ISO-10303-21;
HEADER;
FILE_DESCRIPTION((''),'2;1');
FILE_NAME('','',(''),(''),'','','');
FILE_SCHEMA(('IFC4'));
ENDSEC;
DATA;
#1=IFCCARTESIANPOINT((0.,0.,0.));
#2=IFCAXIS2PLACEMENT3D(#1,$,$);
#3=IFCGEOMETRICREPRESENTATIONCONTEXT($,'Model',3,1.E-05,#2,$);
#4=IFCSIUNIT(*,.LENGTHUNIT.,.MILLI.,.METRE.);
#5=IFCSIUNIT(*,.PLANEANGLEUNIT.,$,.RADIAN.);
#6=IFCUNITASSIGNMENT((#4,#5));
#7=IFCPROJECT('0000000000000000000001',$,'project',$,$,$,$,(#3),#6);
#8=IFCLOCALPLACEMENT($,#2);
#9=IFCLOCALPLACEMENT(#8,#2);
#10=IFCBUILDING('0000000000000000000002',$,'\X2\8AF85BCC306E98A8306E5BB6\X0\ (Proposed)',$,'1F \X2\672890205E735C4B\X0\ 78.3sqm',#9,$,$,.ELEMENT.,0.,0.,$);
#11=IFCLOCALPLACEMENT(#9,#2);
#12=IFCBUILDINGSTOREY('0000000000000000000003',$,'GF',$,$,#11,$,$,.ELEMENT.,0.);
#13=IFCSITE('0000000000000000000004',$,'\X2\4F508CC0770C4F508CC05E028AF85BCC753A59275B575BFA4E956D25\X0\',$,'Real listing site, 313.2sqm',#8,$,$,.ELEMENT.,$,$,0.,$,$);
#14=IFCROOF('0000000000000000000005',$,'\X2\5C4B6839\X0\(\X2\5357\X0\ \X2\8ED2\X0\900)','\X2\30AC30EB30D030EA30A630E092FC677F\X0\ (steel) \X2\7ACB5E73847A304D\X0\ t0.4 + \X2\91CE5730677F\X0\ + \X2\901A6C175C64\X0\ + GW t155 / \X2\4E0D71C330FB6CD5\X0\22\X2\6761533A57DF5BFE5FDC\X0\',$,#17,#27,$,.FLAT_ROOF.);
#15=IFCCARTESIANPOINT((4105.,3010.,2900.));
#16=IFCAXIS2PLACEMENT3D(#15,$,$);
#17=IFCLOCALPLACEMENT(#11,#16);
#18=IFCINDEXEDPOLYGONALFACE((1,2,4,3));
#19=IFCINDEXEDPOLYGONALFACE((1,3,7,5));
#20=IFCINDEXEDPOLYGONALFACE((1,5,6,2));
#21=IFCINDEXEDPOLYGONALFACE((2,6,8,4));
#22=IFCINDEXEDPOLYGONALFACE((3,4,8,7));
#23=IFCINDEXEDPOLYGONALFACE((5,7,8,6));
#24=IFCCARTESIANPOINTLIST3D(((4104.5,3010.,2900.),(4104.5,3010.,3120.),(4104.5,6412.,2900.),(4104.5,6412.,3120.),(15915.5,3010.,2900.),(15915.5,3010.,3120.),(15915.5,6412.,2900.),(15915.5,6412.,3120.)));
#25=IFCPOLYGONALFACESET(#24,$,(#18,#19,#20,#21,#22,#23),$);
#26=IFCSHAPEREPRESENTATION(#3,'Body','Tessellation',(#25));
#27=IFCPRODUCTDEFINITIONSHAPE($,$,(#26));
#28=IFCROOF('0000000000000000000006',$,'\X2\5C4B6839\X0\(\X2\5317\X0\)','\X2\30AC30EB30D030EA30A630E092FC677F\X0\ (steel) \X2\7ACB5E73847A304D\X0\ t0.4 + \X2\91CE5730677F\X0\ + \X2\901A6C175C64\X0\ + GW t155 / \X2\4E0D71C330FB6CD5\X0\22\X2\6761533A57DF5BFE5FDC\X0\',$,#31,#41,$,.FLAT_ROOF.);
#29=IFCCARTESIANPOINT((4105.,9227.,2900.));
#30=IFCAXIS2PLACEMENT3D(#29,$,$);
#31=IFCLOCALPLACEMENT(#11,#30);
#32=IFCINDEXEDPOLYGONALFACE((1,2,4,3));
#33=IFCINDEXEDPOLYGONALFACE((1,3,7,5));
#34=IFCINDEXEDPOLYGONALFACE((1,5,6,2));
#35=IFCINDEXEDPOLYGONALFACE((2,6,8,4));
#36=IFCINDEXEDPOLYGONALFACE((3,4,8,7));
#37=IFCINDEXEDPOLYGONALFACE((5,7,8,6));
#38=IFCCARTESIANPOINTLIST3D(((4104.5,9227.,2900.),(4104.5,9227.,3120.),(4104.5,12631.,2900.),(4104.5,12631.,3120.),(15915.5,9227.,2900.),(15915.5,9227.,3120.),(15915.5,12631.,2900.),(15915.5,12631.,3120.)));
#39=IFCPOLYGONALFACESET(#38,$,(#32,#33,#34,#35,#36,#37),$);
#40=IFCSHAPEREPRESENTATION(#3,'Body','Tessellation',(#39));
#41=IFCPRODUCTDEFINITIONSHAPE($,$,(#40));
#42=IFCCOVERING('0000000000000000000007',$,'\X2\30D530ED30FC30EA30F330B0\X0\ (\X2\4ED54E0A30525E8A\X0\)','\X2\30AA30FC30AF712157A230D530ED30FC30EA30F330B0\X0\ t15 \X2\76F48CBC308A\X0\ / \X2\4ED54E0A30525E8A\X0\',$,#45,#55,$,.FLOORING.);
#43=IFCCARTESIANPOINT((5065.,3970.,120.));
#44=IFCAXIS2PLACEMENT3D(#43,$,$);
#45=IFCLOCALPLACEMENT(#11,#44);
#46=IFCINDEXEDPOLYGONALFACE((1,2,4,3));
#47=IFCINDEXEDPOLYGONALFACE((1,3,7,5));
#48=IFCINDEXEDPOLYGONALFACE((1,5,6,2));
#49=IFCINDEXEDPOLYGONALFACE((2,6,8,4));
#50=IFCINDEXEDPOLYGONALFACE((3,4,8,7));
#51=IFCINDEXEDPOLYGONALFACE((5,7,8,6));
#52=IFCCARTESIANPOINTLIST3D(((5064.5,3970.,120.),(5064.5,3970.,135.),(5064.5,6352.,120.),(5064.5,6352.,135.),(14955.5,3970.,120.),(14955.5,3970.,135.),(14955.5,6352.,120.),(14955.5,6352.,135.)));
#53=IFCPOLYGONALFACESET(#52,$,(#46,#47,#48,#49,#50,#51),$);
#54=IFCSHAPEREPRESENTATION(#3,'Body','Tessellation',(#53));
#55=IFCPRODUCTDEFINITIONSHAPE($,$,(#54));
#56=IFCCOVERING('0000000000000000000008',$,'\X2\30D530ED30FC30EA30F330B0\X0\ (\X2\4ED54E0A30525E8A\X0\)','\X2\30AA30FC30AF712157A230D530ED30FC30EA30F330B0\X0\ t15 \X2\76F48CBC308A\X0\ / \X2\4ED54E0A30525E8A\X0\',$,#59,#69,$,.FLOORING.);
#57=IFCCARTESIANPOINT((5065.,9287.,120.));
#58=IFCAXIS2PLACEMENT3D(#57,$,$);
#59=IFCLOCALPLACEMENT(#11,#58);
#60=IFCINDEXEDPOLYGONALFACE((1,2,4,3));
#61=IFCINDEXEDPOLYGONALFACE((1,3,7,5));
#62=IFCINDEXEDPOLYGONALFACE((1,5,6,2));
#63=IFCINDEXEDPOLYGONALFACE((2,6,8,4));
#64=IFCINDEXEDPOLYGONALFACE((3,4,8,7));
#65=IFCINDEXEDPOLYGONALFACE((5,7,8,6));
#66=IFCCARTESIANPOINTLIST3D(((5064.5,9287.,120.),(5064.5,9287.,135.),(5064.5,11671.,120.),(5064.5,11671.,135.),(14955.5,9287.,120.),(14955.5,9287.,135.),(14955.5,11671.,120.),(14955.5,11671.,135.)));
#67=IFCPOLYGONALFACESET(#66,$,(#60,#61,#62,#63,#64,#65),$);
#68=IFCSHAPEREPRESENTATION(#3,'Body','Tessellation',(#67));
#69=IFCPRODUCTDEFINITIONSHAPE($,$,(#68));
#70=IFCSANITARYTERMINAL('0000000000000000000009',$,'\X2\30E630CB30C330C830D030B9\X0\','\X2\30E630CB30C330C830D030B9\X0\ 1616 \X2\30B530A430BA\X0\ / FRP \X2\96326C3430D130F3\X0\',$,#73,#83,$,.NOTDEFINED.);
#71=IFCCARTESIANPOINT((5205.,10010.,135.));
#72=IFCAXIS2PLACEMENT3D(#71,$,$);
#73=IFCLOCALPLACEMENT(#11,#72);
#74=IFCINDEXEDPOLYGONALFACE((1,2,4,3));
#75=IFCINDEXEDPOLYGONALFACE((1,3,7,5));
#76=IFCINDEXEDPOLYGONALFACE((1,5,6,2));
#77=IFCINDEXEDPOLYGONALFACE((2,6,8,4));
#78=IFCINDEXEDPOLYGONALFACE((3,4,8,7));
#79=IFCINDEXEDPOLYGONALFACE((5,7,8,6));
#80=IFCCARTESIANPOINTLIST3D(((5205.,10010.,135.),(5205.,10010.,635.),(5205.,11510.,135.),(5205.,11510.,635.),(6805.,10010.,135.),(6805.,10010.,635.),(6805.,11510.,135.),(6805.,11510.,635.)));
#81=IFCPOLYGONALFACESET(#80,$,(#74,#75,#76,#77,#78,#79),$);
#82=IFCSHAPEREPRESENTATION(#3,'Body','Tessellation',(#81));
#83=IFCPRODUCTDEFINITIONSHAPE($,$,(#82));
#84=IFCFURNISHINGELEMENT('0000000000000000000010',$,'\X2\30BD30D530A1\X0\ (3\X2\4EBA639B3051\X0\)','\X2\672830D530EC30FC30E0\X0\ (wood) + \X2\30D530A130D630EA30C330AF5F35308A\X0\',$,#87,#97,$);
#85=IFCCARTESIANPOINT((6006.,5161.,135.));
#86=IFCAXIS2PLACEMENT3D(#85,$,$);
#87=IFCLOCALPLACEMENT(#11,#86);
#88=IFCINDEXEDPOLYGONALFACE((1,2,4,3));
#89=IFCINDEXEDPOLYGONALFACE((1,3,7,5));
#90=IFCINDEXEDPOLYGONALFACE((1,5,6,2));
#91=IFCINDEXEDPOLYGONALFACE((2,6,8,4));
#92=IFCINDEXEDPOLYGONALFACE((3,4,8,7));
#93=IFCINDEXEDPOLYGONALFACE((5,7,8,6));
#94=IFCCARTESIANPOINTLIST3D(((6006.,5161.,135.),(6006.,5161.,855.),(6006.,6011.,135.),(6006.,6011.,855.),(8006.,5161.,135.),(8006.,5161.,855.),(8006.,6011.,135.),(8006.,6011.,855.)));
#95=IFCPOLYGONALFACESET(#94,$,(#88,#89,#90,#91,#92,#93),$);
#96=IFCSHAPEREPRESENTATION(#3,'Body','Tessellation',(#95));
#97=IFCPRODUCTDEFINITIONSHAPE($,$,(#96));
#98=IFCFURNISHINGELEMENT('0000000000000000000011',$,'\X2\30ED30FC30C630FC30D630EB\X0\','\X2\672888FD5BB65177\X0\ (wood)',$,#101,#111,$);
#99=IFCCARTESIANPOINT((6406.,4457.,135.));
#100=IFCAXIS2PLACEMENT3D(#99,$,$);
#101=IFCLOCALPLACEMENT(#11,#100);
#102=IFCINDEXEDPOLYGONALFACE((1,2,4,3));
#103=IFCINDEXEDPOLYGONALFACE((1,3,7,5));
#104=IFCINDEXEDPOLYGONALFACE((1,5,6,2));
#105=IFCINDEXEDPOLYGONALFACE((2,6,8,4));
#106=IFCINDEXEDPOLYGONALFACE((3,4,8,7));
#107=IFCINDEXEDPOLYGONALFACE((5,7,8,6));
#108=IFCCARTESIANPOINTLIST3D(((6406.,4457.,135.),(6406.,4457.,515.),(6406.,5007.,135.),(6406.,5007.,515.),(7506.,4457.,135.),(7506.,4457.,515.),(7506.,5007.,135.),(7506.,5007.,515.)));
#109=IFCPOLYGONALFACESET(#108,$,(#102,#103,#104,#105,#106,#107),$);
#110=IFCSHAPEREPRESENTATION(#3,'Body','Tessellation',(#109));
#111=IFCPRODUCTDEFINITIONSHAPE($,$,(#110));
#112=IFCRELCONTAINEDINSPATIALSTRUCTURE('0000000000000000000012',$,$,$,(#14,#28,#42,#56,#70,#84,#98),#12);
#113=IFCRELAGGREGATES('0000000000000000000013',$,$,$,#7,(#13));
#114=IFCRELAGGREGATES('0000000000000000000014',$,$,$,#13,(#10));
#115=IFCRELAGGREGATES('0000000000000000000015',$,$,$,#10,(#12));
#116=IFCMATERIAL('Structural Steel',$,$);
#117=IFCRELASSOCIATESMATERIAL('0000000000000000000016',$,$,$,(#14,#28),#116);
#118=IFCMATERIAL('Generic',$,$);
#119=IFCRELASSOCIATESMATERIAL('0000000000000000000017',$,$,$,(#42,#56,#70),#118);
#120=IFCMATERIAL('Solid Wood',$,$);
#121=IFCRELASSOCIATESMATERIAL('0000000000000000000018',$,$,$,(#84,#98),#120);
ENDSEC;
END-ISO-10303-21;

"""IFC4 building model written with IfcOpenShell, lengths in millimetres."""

from ifc_helpers import new_model, si_unit, frame, frame_2d, origin, place, context, project, spatial, rectangle, extrude, material, element, save


model = new_model("IFC4")

# Units and contexts
model_context = context("Model", 3, precision=1e-05, world=origin())
ifc_project = project(units=[si_unit("LENGTHUNIT", "METRE", prefix="MILLI"), si_unit("PLANEANGLEUNIT", "RADIAN")], contexts=[model_context])

# Site, building, storey
site_placement = place(None, origin())
site = spatial("IfcSite", under=ifc_project, at=site_placement, Name="佐賀県佐賀市諸富町大字寺井津", ObjectType="Real listing site, 313.2sqm", CompositionType="ELEMENT", RefElevation=0.0)
building_placement = place(site_placement, origin())
building = spatial("IfcBuilding", under=site, at=building_placement, Name="諸富の風の家 (Proposed)", ObjectType="1F 木造平屋 78.3sqm", CompositionType="ELEMENT", ElevationOfRefHeight=0.0, ElevationOfTerrain=0.0)
storey_placement = place(building_placement, origin())
storey = spatial("IfcBuildingStorey", under=building, at=storey_placement, Name="GF", CompositionType="ELEMENT", Elevation=0.0)

# Shared definitions
ifc_material_1 = material(Name="Solid Wood")

# Roofs
ifc_material_2 = material(Name="Structural Steel")
roof_1_placement = place(storey_placement, frame((4105.0, 3010.0, 2900.0)))
element("IfcRoof", 1, at=roof_1_placement, inside=storey, material=ifc_material_2, Name="屋根(南 軒900)", Description="ガルバリウム鋼板 (steel) 立平葺き t0.4 + 野地板 + 通気層 + GW t155 / 不燃・法22条区域対応", PredefinedType="FLAT_ROOF", context=model_context, shape_type="SweptSolid", body=[
    extrude(rectangle(XDim=11811.0, YDim=3402.0, at=frame_2d((5905.0, 1701.0))), frame((4105.0, 3010.0, 2900.0)), (0.0, 0.0, 1.0), 220.0),
])
roof_2_placement = place(storey_placement, frame((4105.0, 9227.0, 2900.0)))
element("IfcRoof", 2, at=roof_2_placement, inside=storey, material=ifc_material_2, Name="屋根(北)", Description="ガルバリウム鋼板 (steel) 立平葺き t0.4 + 野地板 + 通気層 + GW t155 / 不燃・法22条区域対応", PredefinedType="FLAT_ROOF", context=model_context, shape_type="SweptSolid", body=[
    extrude(rectangle(XDim=11811.0, YDim=3404.0, at=frame_2d((5905.0, 1702.0))), frame((4105.0, 9227.0, 2900.0)), (0.0, 0.0, 1.0), 220.0),
])

# Coverings
ifc_material_3 = material(Name="Generic")
covering_1_placement = place(storey_placement, frame((5065.0, 3970.0, 120.0)))
element("IfcCovering", 3, at=covering_1_placement, inside=storey, material=ifc_material_3, Name="フローリング (仕上げ床)", Description="オーク無垢フローリング t15 直貼り / 仕上げ床", PredefinedType="FLOORING", context=model_context, shape_type="SweptSolid", body=[
    extrude(rectangle(XDim=9891.0, YDim=2382.0, at=frame_2d((4945.0, 1191.0))), frame((5065.0, 3970.0, 120.0)), (0.0, 0.0, 1.0), 15.0),
])
covering_2_placement = place(storey_placement, frame((5065.0, 9287.0, 120.0)))
element("IfcCovering", 4, at=covering_2_placement, inside=storey, material=ifc_material_3, Name="フローリング (仕上げ床)", Description="オーク無垢フローリング t15 直貼り / 仕上げ床", PredefinedType="FLOORING", context=model_context, shape_type="SweptSolid", body=[
    extrude(rectangle(XDim=9891.0, YDim=2384.0, at=frame_2d((4945.0, 1192.0))), frame((5065.0, 9287.0, 120.0)), (0.0, 0.0, 1.0), 15.0),
])

# Sanitary terminal
sanitary_terminal_placement = place(storey_placement, frame((5205.0, 10010.0, 135.0)))
element("IfcSanitaryTerminal", 5, at=sanitary_terminal_placement, inside=storey, material=ifc_material_3, Name="ユニットバス", Description="ユニットバス 1616 サイズ / FRP 防水パン", PredefinedType="NOTDEFINED", context=model_context, shape_type="SweptSolid", body=[
    extrude(rectangle(XDim=1600.0, YDim=1500.0, at=frame_2d((800.0, 750.0))), frame((5205.0, 10010.0, 135.0)), (0.0, 0.0, 1.0), 500.0),
])

# Furnishing elements
furnishing_1_placement = place(storey_placement, frame((6006.0, 5161.0, 135.0)))
element("IfcFurnishingElement", 6, at=furnishing_1_placement, inside=storey, material=ifc_material_1, Name="ソファ (3人掛け)", Description="木フレーム (wood) + ファブリック張り", context=model_context, shape_type="SweptSolid", body=[
    extrude(rectangle(XDim=2000.0, YDim=850.0, at=frame_2d((1000.0, 425.0))), frame((6006.0, 5161.0, 135.0)), (0.0, 0.0, 1.0), 720.0),
])
furnishing_2_placement = place(storey_placement, frame((6406.0, 4457.0, 135.0)))
element("IfcFurnishingElement", 7, at=furnishing_2_placement, inside=storey, material=ifc_material_1, Name="ローテーブル", Description="木製家具 (wood)", context=model_context, shape_type="SweptSolid", body=[
    extrude(rectangle(XDim=1100.0, YDim=550.0, at=frame_2d((550.0, 275.0))), frame((6406.0, 4457.0, 135.0)), (0.0, 0.0, 1.0), 380.0),
])

save(model, "model.ifc")
